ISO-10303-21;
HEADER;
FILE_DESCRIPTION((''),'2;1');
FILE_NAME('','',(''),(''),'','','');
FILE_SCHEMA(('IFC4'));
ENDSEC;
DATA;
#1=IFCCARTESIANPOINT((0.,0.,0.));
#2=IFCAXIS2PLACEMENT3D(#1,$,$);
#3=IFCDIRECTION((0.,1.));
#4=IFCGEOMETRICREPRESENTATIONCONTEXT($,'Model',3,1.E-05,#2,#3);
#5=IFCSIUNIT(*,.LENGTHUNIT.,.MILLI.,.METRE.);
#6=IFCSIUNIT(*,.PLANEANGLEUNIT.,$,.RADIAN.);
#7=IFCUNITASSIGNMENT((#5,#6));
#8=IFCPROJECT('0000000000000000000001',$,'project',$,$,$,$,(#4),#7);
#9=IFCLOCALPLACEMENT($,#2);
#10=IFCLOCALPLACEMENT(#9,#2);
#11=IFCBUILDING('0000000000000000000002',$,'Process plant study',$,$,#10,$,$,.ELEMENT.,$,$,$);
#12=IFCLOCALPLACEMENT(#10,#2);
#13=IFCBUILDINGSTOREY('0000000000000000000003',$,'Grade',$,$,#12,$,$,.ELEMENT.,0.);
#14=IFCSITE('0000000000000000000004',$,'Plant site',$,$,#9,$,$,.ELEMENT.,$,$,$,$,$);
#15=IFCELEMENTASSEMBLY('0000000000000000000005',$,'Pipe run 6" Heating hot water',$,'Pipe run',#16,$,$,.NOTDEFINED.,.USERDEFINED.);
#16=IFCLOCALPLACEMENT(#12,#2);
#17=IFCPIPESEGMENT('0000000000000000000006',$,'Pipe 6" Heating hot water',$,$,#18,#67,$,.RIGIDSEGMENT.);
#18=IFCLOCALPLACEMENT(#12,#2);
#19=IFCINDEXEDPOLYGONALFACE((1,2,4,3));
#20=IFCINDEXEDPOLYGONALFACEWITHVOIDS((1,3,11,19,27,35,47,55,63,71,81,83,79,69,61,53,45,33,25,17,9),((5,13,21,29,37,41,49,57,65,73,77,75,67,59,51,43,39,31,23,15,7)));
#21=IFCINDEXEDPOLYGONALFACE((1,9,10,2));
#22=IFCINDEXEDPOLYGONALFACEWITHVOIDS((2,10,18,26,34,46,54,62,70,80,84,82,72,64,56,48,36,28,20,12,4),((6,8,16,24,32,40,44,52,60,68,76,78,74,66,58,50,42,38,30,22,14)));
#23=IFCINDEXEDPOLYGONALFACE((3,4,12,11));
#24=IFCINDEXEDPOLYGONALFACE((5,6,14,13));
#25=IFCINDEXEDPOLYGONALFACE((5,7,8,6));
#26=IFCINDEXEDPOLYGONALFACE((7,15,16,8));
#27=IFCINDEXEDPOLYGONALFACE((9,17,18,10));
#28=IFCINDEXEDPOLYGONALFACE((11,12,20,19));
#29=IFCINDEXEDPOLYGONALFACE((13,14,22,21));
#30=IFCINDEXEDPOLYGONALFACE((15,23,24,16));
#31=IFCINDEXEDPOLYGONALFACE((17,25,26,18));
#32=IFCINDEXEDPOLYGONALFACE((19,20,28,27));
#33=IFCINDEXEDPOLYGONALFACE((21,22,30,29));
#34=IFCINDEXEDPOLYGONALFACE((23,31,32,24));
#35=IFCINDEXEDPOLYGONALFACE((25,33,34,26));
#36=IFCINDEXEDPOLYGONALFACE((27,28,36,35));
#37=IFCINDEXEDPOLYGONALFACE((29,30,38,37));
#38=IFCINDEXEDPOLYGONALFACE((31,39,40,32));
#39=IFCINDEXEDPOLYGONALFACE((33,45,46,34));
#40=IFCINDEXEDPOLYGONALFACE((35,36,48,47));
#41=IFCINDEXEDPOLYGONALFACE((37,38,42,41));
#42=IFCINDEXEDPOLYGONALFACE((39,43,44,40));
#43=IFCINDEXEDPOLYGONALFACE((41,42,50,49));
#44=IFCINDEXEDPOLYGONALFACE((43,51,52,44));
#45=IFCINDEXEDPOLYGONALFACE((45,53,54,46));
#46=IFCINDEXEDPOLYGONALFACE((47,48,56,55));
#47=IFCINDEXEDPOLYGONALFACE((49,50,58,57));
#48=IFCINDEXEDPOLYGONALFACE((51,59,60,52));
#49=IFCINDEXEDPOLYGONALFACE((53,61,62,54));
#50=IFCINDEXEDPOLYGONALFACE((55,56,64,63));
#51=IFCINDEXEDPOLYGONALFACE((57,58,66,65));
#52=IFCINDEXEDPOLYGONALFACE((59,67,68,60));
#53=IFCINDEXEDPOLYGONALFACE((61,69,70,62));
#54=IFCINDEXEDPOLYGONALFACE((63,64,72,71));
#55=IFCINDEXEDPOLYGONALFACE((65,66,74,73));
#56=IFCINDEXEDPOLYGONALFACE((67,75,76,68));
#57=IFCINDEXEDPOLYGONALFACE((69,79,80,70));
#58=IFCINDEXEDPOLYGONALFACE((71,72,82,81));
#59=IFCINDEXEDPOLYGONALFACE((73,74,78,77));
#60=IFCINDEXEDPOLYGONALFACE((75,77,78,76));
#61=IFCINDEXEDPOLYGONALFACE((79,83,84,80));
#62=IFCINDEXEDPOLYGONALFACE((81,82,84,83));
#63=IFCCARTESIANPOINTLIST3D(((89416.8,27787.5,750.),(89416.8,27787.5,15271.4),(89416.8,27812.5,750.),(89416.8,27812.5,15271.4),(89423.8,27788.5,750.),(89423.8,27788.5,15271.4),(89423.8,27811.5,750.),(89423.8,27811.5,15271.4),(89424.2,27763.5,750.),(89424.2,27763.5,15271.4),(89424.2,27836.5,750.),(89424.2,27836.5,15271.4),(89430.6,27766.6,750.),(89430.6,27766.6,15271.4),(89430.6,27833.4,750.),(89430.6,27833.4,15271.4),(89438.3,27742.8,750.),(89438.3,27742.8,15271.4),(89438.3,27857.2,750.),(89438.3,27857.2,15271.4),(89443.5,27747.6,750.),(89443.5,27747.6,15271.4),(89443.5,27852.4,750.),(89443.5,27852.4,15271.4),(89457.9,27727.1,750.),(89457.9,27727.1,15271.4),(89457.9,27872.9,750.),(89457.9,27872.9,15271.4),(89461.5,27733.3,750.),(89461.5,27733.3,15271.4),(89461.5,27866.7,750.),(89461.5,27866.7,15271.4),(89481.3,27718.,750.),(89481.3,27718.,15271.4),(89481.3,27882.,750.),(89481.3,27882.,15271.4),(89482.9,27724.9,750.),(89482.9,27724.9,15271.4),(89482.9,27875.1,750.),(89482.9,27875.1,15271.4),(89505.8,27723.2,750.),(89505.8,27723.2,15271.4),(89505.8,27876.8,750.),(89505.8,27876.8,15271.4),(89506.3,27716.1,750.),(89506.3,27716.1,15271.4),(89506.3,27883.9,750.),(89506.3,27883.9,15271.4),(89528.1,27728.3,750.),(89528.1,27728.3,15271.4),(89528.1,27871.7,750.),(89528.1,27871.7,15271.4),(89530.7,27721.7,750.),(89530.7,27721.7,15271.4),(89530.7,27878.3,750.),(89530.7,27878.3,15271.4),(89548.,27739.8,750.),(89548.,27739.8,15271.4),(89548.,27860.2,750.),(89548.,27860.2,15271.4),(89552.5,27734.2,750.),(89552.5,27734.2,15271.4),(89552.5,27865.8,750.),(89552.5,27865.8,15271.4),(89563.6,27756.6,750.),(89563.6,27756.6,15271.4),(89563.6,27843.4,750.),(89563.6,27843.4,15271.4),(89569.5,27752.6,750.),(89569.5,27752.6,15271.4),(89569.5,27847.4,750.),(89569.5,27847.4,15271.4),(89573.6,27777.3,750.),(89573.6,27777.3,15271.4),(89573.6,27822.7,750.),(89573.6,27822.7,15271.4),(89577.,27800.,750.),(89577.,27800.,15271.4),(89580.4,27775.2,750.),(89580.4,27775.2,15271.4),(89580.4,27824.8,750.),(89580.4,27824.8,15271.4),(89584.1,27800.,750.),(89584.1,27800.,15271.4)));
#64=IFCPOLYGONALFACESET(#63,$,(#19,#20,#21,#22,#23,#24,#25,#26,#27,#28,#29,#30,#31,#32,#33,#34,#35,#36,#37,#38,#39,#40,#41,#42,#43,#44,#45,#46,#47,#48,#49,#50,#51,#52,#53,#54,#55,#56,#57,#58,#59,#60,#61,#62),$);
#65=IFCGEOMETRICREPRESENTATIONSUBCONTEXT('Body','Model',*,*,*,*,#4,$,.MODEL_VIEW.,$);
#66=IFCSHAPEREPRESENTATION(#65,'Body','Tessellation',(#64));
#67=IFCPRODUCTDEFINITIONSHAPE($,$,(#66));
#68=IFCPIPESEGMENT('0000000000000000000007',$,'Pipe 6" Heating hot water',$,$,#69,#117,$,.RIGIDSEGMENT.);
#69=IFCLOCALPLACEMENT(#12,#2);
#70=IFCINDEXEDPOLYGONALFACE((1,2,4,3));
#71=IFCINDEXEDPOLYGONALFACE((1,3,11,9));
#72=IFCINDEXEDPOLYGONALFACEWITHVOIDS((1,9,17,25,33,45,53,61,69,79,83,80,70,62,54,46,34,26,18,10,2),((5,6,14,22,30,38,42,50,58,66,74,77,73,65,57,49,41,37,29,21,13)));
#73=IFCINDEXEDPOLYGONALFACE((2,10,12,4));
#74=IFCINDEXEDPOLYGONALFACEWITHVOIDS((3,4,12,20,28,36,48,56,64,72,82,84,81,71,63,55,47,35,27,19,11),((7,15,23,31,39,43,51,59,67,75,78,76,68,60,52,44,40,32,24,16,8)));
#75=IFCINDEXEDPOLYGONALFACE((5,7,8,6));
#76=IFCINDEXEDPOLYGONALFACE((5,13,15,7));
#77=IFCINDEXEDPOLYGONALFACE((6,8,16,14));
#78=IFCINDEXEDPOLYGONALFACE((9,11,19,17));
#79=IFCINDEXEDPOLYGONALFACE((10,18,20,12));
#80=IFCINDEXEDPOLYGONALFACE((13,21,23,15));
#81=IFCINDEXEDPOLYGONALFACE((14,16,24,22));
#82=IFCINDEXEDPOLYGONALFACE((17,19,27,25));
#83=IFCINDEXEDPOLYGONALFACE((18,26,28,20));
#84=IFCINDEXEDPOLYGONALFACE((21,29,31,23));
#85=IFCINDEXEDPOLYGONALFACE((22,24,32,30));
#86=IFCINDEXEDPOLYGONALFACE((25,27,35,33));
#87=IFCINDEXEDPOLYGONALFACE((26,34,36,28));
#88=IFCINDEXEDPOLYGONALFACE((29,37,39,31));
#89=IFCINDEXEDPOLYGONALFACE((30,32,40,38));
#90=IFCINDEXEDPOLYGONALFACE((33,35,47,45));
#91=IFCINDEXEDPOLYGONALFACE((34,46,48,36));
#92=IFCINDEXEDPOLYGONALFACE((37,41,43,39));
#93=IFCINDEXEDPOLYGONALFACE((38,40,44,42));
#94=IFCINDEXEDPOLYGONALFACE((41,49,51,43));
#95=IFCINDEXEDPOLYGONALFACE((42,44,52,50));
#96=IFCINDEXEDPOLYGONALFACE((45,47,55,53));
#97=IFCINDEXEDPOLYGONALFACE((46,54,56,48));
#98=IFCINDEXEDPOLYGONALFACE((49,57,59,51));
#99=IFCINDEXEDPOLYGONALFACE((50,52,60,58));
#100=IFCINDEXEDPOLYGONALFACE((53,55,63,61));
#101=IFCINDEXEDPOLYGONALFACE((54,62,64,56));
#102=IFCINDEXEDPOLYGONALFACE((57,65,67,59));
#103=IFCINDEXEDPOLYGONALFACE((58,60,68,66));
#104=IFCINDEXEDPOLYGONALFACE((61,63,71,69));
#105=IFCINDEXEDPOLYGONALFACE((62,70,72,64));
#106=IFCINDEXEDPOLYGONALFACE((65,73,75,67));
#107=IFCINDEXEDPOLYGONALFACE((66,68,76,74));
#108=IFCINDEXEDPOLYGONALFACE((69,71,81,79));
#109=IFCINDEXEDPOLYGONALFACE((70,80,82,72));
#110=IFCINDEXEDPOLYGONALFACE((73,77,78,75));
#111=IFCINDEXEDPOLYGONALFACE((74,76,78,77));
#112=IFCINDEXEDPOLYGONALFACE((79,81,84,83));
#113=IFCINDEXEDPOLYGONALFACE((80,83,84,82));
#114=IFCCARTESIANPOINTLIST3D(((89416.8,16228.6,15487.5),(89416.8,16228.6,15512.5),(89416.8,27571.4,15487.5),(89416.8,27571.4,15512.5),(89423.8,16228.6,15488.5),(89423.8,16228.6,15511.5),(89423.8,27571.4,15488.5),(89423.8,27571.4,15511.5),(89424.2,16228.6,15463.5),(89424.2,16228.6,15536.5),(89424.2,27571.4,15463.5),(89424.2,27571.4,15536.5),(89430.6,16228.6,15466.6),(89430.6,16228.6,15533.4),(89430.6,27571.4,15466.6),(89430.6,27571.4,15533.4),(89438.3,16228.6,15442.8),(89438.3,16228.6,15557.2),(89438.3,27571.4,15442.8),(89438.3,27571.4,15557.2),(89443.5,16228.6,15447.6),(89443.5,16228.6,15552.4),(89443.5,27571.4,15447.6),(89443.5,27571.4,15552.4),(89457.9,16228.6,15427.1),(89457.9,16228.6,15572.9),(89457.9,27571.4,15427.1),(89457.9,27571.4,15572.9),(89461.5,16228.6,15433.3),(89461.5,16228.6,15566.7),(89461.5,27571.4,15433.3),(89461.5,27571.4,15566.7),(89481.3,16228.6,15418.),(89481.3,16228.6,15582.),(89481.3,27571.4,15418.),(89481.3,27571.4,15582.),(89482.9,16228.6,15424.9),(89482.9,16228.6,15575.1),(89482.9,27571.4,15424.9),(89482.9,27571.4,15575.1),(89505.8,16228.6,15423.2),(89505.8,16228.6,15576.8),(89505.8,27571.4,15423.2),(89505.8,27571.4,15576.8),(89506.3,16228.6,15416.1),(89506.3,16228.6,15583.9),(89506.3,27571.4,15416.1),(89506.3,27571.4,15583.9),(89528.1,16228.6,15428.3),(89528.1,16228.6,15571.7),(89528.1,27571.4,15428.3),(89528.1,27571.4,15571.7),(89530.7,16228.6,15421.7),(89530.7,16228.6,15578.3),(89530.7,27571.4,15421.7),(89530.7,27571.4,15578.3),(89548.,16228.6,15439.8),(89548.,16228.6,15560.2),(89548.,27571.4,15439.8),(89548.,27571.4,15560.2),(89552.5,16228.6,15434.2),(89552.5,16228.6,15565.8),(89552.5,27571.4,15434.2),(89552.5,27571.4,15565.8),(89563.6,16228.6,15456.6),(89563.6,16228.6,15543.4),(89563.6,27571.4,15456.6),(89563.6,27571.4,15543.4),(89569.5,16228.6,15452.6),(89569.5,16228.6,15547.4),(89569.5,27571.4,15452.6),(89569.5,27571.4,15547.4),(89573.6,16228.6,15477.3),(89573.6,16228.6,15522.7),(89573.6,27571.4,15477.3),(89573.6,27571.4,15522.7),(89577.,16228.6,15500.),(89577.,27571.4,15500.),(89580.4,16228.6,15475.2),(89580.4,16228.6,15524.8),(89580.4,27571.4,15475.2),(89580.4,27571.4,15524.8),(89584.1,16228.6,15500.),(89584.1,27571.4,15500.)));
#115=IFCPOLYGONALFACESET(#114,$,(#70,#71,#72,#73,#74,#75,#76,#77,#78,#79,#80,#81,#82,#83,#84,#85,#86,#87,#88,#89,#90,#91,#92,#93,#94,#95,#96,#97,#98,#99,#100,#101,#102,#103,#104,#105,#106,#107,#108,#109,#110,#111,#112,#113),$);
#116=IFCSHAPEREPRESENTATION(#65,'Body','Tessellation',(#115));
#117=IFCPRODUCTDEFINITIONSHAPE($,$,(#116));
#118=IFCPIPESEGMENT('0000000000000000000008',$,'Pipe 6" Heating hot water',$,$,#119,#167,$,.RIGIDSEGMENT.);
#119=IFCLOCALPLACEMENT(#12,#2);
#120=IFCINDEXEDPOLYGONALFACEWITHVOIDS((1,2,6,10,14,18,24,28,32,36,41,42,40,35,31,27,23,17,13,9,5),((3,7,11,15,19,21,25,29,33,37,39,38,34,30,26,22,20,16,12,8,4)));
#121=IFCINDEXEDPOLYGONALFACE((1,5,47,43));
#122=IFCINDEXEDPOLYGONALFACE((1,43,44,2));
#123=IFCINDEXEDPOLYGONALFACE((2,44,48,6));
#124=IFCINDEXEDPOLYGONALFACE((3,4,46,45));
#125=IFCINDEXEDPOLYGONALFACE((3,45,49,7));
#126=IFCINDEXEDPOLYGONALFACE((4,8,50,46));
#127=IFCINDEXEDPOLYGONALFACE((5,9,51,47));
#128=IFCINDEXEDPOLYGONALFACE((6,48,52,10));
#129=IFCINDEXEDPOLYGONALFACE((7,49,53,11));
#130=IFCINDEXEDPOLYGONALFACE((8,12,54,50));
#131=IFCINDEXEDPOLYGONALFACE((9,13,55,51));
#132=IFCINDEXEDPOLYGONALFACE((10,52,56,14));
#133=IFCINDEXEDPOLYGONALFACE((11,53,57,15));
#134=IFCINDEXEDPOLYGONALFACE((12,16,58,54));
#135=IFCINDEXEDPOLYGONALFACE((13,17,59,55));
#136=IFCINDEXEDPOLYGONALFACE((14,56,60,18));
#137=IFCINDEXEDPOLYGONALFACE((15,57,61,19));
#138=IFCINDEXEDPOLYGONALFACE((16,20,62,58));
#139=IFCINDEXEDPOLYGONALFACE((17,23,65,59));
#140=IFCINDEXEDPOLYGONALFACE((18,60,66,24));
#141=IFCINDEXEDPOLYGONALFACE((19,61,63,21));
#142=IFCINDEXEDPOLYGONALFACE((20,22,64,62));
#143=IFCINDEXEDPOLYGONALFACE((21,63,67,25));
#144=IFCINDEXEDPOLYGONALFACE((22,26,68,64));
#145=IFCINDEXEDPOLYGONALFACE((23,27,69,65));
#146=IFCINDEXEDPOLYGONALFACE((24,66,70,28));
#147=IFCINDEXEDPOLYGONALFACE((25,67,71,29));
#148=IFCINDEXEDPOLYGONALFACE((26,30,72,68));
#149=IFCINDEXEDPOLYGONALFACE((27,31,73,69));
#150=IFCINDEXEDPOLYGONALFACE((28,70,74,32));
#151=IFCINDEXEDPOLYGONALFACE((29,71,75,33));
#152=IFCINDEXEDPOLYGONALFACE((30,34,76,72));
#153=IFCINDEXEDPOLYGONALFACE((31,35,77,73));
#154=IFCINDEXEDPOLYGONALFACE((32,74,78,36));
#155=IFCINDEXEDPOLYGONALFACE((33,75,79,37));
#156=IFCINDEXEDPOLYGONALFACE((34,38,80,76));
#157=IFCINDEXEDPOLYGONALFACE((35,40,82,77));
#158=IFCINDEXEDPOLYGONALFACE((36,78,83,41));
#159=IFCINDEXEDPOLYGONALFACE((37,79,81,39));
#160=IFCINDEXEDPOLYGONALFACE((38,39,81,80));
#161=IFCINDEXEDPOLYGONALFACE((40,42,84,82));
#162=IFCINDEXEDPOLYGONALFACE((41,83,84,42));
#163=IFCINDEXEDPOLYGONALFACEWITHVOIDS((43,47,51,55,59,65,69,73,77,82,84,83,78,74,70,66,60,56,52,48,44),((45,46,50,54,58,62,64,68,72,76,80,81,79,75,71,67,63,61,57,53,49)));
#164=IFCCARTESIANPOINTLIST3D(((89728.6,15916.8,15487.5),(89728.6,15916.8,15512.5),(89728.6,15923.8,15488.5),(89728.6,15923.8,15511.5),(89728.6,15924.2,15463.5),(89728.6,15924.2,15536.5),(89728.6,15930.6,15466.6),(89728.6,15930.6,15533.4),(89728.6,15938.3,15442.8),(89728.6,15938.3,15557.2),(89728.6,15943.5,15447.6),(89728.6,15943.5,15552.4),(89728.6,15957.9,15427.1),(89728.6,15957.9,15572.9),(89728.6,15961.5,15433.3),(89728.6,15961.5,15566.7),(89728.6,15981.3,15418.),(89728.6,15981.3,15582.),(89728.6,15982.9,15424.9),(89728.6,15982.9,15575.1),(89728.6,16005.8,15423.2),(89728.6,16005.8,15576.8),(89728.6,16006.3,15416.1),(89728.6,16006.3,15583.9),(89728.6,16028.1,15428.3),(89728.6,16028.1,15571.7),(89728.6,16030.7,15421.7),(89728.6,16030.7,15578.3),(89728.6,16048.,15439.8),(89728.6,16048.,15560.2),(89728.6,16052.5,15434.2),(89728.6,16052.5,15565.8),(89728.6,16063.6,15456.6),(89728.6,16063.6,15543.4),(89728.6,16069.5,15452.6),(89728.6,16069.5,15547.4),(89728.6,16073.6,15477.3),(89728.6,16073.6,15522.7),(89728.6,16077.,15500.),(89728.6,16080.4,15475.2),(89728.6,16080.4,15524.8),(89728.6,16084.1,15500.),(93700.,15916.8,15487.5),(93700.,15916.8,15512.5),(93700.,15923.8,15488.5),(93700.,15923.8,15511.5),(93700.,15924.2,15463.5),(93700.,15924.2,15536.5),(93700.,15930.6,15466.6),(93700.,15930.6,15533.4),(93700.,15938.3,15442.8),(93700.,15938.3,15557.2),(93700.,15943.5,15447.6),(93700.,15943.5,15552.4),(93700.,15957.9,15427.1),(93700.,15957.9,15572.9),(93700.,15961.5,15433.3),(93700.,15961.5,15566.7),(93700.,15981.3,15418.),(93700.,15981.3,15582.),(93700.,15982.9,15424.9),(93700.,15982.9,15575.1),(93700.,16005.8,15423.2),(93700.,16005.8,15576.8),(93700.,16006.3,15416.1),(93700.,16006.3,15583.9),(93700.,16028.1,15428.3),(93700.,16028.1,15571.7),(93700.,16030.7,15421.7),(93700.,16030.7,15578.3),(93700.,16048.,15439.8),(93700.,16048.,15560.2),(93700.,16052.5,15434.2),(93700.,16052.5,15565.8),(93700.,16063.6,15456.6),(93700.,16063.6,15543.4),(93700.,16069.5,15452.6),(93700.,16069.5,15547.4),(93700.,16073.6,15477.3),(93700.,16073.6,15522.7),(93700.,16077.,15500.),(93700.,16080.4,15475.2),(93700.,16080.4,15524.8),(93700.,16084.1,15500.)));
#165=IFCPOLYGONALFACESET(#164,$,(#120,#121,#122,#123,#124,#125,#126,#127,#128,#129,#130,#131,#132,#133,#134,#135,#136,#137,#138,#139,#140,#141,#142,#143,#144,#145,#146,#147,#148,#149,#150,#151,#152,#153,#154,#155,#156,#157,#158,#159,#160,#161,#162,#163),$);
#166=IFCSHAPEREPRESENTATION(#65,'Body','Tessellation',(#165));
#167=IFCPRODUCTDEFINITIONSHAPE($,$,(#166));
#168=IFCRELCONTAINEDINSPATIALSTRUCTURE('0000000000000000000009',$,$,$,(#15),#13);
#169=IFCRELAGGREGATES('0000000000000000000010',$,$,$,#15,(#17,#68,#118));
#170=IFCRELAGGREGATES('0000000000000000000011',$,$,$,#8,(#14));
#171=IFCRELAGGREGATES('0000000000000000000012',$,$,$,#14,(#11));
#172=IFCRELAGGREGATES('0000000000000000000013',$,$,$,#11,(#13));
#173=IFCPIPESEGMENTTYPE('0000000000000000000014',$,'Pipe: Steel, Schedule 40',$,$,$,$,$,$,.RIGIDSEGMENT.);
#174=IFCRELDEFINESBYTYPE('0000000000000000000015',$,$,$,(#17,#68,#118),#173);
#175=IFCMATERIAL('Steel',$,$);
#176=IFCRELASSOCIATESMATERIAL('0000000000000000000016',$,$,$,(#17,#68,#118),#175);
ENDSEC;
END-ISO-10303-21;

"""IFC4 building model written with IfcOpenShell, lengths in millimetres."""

from ifc_helpers import new_model, si_unit, direction, frame, origin, origin_with_axes, origin_2d, place, context, subcontext, project, spatial, hollow_circle, extrude, material, type_object, element, aggregate, save


model = new_model("IFC4")

# Units and contexts
model_context = context("Model", 3, precision=1e-05, world=origin(), true_north=direction((0.0, 1.0)))
body_context = subcontext(model_context, "Body", "Model", "MODEL_VIEW")
ifc_project = project(units=[si_unit("LENGTHUNIT", "METRE", prefix="MILLI"), si_unit("PLANEANGLEUNIT", "RADIAN")], contexts=[model_context])

# Site, building, storey
site_placement = place(None, origin())
site = spatial("IfcSite", under=ifc_project, at=site_placement, Name="Plant site", CompositionType="ELEMENT")
building_placement = place(site_placement, origin())
building = spatial("IfcBuilding", under=site, at=building_placement, Name="Process plant study", CompositionType="ELEMENT")
storey_placement = place(building_placement, origin())
storey = spatial("IfcBuildingStorey", under=building, at=storey_placement, Name="Grade", CompositionType="ELEMENT", Elevation=0.0)

# Element assembly, pipe segments
assembly_1_placement = place(storey_placement, origin_with_axes())
assembly_1 = element("IfcElementAssembly", 1, at=assembly_1_placement, inside=storey, Name="Pipe run 6\" Heating hot water", ObjectType="Pipe run", AssemblyPlace="NOTDEFINED", PredefinedType="USERDEFINED")
ifc_material = material(Name="Steel")
pipe_segment_type = type_object("IfcPipeSegmentType", Name="Pipe: Steel, Schedule 40", PredefinedType="RIGIDSEGMENT")
pipe_segment_1_placement = place(storey_placement, origin_with_axes())
pipe_segment_1 = element("IfcPipeSegment", 2, at=pipe_segment_1_placement, type_object=pipe_segment_type, material=ifc_material, Name="Pipe 6\" Heating hot water", PredefinedType="RIGIDSEGMENT", context=body_context, shape_type="SweptSolid", body=[
    extrude(hollow_circle(Radius=84.1, WallThickness=7.1, at=origin_2d()), frame((89500.0, 27800.0, 750.0), z_axis=(0.0, 0.0, 1.0), x_axis=(1.0, 0.0, 0.0)), (0.0, 0.0, 1.0), 14521.4),
])
pipe_segment_2_placement = place(storey_placement, origin_with_axes())
pipe_segment_2 = element("IfcPipeSegment", 3, at=pipe_segment_2_placement, type_object=pipe_segment_type, material=ifc_material, Name="Pipe 6\" Heating hot water", PredefinedType="RIGIDSEGMENT", context=body_context, shape_type="SweptSolid", body=[
    extrude(hollow_circle(Radius=84.1, WallThickness=7.1, at=origin_2d()), frame((89500.0, 27571.4, 15500.0), z_axis=(0.0, -1.0, 0.0), x_axis=(1.0, 0.0, 0.0)), (0.0, 0.0, 1.0), 11342.8),
])
pipe_segment_3_placement = place(storey_placement, origin_with_axes())
pipe_segment_3 = element("IfcPipeSegment", 4, at=pipe_segment_3_placement, type_object=pipe_segment_type, material=ifc_material, Name="Pipe 6\" Heating hot water", PredefinedType="RIGIDSEGMENT", context=body_context, shape_type="SweptSolid", body=[
    extrude(hollow_circle(Radius=84.1, WallThickness=7.1, at=origin_2d()), frame((89728.6, 16000.0, 15500.0), z_axis=(1.0, 0.0, 0.0), x_axis=(0.0, 1.0, 0.0)), (0.0, 0.0, 1.0), 3971.4),
])

aggregate(assembly_1, [pipe_segment_1, pipe_segment_2, pipe_segment_3])

save(model, "model.ifc")
